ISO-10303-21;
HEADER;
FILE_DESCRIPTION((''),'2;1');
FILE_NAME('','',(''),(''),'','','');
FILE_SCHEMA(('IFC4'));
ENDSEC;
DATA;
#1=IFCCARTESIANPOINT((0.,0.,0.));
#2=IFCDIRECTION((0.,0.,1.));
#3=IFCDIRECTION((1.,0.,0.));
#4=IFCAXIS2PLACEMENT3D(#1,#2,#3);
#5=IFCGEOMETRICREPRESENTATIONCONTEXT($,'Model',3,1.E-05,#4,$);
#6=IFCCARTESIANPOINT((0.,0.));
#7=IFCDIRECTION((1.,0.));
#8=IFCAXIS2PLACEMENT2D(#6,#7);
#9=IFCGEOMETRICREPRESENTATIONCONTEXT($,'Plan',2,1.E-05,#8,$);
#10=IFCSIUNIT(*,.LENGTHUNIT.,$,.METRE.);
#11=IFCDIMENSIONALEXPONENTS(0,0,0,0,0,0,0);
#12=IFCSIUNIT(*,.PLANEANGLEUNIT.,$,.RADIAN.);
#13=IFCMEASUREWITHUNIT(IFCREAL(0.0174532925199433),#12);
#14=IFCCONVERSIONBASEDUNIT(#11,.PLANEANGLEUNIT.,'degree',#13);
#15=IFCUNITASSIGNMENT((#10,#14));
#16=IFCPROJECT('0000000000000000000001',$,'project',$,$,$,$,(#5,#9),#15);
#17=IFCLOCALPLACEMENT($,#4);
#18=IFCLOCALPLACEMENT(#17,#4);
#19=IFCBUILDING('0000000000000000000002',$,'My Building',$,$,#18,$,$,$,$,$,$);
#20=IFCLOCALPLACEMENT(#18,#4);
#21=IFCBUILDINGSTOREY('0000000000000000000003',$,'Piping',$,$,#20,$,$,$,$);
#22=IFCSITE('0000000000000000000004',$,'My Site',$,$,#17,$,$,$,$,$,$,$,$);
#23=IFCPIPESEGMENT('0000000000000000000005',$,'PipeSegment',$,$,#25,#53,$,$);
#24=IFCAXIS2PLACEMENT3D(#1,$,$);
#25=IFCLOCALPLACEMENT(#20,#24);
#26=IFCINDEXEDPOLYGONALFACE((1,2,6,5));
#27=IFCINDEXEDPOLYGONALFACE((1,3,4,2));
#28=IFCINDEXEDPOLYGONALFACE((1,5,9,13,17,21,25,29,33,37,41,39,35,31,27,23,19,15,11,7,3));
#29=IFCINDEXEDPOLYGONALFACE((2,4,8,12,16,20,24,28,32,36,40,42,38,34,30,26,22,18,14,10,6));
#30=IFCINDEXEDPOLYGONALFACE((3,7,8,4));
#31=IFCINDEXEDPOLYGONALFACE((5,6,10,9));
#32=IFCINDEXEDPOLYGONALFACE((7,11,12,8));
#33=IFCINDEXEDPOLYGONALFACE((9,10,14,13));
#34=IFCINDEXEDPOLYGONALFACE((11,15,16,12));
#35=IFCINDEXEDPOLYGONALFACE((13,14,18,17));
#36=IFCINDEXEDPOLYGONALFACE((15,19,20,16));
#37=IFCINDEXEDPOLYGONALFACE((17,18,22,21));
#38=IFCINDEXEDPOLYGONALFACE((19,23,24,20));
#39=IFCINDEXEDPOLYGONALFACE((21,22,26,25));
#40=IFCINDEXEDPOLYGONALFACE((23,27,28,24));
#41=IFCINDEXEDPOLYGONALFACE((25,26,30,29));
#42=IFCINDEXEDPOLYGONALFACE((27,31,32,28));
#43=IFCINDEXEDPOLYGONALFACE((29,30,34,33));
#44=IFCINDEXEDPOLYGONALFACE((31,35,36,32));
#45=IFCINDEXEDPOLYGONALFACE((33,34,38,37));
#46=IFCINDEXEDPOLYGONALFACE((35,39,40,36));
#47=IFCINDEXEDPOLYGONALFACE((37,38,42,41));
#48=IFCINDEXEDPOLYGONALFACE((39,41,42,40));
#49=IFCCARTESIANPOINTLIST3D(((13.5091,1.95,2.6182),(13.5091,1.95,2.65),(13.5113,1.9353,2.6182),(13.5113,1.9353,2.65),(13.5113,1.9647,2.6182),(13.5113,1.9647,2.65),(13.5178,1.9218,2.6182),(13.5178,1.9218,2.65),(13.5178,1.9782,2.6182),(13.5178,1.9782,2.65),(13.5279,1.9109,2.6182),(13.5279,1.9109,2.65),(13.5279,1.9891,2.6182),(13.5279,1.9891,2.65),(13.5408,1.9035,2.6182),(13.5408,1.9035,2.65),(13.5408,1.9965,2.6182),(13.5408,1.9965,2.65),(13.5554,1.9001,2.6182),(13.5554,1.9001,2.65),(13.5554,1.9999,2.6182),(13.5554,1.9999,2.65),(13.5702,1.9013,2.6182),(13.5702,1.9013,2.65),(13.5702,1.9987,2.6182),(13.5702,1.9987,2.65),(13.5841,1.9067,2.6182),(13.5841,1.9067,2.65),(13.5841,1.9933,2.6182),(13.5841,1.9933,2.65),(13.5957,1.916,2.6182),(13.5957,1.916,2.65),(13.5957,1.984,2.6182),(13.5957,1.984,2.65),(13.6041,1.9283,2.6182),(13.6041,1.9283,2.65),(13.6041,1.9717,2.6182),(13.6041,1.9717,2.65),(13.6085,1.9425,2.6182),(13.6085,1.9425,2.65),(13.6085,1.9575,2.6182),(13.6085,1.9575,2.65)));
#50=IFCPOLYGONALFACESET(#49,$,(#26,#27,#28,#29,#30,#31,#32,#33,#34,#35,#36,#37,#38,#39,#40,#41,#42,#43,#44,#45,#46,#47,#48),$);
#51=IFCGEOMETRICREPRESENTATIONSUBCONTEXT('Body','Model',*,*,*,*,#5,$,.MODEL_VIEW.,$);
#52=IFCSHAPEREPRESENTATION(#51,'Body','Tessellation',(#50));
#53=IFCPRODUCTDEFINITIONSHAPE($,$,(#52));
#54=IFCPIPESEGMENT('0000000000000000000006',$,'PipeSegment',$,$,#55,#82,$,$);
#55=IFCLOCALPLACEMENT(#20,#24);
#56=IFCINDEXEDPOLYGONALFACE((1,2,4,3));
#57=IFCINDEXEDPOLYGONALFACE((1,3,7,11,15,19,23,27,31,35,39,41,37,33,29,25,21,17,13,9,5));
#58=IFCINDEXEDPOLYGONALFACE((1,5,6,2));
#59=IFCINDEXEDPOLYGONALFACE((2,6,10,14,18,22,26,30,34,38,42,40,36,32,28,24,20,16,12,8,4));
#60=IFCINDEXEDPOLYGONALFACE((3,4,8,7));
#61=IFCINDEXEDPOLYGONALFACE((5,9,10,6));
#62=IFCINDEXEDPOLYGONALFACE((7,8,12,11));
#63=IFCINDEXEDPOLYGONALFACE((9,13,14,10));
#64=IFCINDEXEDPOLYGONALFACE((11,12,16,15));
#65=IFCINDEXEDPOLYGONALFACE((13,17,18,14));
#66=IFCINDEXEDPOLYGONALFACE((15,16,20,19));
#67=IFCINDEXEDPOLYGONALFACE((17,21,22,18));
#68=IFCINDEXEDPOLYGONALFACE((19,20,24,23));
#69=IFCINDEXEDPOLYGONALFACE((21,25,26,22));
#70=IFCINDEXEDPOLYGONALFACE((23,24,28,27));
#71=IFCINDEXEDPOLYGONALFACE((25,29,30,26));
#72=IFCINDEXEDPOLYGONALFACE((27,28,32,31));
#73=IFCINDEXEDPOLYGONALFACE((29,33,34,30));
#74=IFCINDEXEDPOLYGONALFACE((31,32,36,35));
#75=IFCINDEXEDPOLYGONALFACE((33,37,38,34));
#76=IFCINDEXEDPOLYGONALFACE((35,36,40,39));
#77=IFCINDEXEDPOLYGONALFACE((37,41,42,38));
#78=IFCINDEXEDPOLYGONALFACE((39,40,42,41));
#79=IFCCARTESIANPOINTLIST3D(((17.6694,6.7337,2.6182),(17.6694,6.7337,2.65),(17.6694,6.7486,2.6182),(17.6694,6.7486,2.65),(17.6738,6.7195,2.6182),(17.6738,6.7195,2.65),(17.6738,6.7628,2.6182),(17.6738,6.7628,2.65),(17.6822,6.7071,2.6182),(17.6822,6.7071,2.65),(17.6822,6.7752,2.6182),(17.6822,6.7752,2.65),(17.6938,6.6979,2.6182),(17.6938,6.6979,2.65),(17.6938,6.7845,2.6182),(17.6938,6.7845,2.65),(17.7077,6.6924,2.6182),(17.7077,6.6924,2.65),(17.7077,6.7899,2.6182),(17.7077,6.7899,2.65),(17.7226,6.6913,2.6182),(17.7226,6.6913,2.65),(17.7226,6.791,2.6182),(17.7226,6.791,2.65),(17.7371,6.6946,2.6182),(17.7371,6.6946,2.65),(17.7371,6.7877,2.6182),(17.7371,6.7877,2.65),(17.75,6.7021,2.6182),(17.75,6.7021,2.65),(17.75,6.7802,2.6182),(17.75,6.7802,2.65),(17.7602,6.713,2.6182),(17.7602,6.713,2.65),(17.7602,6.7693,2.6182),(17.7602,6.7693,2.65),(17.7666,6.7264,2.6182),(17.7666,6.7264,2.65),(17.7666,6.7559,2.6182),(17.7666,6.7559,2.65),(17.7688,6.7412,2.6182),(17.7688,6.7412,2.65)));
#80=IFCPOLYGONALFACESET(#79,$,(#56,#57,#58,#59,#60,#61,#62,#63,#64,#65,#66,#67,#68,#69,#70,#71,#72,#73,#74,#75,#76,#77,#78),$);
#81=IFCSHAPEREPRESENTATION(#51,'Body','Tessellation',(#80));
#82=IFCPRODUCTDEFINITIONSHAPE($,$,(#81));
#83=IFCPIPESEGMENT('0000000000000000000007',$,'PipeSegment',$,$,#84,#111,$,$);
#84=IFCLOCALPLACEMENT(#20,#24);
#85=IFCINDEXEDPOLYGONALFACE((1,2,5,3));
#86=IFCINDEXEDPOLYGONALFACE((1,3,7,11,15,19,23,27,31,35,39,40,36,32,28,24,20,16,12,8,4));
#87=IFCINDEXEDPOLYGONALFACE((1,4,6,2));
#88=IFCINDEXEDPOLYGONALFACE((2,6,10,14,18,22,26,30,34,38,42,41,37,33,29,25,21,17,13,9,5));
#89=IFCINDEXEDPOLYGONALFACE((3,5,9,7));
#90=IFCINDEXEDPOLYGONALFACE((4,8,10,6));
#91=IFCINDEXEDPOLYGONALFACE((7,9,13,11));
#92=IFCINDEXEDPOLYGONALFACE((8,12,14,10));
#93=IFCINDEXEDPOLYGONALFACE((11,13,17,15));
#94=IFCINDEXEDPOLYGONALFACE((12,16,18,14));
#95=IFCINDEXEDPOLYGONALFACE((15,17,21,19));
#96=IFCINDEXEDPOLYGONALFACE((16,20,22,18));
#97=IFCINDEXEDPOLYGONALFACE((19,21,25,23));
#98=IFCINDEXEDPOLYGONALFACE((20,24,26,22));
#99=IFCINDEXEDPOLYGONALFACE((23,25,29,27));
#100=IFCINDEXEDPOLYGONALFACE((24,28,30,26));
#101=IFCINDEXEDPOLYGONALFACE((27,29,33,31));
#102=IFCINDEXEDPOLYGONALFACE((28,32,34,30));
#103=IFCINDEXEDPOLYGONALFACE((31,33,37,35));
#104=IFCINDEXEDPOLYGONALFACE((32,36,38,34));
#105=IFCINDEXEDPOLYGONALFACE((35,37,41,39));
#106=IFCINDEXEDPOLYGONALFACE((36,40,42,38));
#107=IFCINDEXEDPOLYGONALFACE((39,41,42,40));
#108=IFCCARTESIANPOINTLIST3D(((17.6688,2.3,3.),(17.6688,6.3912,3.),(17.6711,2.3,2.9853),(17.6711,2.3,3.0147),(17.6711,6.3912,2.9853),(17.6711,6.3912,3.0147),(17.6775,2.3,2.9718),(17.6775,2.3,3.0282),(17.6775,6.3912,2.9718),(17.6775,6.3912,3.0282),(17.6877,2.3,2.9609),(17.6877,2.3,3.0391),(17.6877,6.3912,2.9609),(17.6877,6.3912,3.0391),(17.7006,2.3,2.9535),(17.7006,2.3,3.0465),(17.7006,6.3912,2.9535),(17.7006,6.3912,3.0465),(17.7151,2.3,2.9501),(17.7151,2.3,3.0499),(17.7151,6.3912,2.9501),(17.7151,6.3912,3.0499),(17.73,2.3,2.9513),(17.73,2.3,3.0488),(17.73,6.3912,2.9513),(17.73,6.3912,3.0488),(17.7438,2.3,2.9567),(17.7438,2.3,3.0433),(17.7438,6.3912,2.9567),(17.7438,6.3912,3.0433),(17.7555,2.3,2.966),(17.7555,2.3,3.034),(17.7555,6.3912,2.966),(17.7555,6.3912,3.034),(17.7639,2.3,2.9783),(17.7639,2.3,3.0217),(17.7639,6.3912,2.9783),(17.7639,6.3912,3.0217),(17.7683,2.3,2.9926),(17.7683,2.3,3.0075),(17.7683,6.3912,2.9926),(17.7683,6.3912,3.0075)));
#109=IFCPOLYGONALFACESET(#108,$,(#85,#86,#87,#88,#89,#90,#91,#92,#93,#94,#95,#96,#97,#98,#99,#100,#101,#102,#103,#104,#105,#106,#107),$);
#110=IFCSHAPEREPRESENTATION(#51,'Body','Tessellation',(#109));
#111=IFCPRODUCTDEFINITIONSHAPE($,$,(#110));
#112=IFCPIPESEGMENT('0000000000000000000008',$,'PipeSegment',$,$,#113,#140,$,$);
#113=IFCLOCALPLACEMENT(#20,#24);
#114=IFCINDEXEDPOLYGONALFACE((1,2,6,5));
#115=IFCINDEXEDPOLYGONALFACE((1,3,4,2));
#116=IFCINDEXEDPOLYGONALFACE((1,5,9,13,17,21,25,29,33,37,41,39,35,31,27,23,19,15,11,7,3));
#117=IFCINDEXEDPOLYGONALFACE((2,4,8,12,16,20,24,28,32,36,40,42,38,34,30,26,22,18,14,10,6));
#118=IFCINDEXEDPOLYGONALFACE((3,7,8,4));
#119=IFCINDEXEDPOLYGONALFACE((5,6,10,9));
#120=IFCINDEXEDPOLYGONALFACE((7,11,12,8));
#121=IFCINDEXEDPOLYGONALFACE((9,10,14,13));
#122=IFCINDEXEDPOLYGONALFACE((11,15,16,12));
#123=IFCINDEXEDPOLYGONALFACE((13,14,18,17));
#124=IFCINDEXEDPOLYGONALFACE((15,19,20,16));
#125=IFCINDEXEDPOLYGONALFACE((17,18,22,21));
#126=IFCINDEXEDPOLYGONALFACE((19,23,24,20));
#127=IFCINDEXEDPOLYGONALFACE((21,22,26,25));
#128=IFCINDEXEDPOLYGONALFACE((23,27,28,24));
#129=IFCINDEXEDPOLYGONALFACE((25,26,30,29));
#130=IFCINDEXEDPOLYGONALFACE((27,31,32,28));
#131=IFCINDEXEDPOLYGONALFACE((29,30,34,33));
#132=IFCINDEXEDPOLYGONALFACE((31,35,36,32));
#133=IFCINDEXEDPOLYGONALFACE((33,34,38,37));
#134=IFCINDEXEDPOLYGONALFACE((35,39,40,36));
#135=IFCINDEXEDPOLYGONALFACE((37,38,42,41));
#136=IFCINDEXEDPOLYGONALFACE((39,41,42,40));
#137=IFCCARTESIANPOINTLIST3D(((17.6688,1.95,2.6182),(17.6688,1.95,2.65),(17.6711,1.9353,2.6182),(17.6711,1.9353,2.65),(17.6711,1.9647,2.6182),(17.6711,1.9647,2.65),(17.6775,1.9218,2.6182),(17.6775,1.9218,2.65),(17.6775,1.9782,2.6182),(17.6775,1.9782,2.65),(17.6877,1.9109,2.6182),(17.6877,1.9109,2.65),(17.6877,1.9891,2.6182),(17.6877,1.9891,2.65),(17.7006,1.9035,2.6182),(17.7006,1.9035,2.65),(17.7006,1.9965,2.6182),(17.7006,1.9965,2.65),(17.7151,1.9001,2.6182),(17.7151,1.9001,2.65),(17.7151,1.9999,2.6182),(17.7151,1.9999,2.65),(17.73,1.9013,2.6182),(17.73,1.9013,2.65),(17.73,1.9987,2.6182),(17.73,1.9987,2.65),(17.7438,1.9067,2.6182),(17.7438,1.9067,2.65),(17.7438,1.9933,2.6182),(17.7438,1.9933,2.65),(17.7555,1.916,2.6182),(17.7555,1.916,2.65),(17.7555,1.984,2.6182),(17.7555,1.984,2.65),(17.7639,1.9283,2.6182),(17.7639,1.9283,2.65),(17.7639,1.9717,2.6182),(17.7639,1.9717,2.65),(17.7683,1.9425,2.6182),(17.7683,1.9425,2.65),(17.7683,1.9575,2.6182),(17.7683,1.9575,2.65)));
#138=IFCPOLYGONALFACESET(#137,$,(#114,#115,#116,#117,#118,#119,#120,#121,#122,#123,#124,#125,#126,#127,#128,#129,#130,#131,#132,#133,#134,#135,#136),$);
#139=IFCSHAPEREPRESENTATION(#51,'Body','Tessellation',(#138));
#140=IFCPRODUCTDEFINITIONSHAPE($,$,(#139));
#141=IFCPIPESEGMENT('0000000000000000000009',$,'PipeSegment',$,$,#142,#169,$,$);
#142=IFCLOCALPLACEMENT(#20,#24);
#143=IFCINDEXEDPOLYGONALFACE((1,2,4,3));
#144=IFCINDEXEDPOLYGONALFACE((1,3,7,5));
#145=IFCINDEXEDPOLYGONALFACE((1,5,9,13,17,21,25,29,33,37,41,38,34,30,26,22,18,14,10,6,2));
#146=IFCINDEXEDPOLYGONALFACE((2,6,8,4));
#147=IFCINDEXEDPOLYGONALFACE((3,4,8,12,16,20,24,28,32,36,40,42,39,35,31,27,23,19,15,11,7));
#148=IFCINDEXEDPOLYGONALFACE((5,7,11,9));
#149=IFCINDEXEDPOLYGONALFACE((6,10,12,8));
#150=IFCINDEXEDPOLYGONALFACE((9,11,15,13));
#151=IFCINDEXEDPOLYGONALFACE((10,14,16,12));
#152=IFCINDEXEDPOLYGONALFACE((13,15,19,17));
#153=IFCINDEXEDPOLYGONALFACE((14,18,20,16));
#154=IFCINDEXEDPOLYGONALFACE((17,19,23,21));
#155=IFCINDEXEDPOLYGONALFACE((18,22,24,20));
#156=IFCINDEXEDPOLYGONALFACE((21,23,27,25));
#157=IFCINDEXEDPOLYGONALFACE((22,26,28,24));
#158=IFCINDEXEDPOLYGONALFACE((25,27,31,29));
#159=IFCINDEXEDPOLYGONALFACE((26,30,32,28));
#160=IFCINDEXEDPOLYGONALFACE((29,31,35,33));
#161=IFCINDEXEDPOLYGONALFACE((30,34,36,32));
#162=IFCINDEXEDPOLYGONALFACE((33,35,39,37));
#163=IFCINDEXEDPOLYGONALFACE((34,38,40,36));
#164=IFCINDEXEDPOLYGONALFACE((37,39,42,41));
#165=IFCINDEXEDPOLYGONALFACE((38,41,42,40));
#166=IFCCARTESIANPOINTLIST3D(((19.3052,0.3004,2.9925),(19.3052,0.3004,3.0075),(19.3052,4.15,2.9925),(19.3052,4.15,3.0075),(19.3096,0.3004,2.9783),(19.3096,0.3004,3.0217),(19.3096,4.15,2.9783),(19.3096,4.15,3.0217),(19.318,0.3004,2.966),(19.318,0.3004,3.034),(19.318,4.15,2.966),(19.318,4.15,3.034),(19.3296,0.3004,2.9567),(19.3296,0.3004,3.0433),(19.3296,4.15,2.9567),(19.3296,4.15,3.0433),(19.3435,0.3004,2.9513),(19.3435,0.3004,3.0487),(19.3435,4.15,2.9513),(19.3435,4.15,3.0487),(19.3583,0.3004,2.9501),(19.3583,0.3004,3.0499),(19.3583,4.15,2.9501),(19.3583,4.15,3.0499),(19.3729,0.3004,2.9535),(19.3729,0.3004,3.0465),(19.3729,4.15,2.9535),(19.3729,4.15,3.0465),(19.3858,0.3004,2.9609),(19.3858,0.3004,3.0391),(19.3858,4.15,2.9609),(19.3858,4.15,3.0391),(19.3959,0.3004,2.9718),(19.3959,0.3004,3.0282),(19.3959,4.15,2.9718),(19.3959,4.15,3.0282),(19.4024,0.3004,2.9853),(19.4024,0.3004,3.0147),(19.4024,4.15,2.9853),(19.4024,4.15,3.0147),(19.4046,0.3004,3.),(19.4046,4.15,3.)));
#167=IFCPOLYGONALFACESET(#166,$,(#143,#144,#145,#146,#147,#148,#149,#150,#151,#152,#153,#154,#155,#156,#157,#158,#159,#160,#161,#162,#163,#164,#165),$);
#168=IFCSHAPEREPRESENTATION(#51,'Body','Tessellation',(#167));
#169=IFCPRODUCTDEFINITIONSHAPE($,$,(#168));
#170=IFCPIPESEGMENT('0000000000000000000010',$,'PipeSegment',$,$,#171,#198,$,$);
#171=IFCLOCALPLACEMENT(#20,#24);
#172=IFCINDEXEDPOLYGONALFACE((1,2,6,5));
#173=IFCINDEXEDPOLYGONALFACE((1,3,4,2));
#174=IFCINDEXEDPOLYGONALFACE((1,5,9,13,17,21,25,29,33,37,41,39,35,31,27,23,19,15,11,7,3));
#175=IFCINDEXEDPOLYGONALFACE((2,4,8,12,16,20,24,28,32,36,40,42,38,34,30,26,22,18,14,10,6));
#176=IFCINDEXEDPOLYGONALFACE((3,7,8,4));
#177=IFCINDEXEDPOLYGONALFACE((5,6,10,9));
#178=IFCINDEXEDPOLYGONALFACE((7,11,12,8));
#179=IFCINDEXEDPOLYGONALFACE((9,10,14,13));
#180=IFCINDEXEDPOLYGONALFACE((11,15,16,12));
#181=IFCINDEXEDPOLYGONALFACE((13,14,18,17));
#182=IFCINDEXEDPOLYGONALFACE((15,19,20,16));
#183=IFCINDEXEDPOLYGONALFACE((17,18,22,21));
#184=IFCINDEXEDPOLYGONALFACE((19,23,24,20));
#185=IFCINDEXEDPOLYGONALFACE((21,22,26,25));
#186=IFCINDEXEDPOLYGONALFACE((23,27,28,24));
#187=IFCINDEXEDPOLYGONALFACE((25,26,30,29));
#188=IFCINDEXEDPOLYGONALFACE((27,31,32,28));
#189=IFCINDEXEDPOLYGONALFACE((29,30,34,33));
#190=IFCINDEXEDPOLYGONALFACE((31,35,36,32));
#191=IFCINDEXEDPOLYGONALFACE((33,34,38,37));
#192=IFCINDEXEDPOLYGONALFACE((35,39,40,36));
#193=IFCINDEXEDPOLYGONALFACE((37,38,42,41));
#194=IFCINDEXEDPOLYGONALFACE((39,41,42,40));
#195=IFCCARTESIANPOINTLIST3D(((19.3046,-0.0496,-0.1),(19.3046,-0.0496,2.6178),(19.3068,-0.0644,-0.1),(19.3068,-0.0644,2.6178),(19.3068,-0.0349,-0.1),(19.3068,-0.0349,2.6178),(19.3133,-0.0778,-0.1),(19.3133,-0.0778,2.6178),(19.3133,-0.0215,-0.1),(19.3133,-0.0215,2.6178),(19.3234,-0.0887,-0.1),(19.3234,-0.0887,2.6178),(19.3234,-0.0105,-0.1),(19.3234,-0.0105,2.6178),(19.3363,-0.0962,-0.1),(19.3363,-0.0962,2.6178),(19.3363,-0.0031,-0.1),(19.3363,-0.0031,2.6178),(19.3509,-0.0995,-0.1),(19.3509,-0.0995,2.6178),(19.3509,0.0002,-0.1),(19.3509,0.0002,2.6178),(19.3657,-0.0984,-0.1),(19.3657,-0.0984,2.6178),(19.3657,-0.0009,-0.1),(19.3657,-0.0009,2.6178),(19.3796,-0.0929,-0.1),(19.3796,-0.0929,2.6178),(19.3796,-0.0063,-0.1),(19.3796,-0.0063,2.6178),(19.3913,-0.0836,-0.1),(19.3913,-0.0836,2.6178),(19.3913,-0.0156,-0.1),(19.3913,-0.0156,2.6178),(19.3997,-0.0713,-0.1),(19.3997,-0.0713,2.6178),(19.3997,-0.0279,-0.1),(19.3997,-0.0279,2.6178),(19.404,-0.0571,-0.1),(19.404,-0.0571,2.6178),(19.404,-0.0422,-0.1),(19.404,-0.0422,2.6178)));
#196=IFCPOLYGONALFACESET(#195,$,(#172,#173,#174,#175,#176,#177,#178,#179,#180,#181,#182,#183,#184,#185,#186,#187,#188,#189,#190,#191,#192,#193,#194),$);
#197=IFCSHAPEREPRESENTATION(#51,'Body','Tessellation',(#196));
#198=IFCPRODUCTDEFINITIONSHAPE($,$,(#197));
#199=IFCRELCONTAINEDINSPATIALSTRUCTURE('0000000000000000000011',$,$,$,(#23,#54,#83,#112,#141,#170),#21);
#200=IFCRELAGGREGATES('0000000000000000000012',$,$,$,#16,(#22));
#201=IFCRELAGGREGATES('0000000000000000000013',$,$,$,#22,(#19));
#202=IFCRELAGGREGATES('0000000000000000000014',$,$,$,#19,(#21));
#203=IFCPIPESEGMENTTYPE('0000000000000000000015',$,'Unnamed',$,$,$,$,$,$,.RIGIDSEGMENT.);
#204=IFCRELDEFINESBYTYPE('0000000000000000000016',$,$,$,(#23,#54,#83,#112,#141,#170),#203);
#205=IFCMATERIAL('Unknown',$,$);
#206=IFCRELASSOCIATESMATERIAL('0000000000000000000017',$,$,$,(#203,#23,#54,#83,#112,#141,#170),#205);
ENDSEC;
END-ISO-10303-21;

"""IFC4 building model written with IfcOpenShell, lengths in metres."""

from ifc_helpers import new_model, entity, si_unit, converted_unit, frame, origin_with_axes, origin_2d_with_axis, place, context, subcontext, project, spatial, circle, extrude, material, material_profile, profile_set, profile_usage, type_object, element, save


model = new_model("IFC4")

# Units and contexts
model_context = context("Model", 3, precision=1e-05, world=origin_with_axes())
plan_context = context("Plan", 2, precision=1e-05, world=origin_2d_with_axis())
body_context = subcontext(model_context, "Body", "Model", "MODEL_VIEW")
ifc_project = project(units=[si_unit("LENGTHUNIT", "METRE"), converted_unit("PLANEANGLEUNIT", "degree", entity("IfcReal", 0.0174532925199433), si_unit("PLANEANGLEUNIT", "RADIAN"), dimensions=[0, 0, 0, 0, 0, 0, 0])], contexts=[model_context, plan_context])

# Site, building, storey
site_placement = place(None, origin_with_axes())
site = spatial("IfcSite", under=ifc_project, at=site_placement, Name="My Site")
building_placement = place(site_placement, origin_with_axes())
building = spatial("IfcBuilding", under=site, at=building_placement, Name="My Building")
storey_placement = place(building_placement, origin_with_axes())
storey = spatial("IfcBuildingStorey", under=building, at=storey_placement, Name="Piping")

# Pipe segments
ifc_material = material(Name="Unknown")
ifc_material_profile = material_profile(ifc_material, circle(Radius=0.05))
ifc_profile_set = profile_set([ifc_material_profile])
pipe_segment_type = type_object("IfcPipeSegmentType", Name="Unnamed", PredefinedType="RIGIDSEGMENT", material=ifc_profile_set)
ifc_profile_usage_1 = profile_usage(ifc_profile_set, cardinal=5)
pipe_segment_1_placement = place(storey_placement, frame((13.5591, 1.95, 2.65), z_axis=(0.0, 0.0, -1.0), x_axis=(-1.0, 0.0, 0.0)))
element("IfcPipeSegment", 1, at=pipe_segment_1_placement, inside=storey, type_object=pipe_segment_type, material=ifc_profile_usage_1, Name="PipeSegment", context=body_context, shape_type="SweptSolid", body=[
    extrude(circle(Radius=0.05), origin_with_axes(), (0.0, 0.0, 1.0), 0.0318),
])
ifc_profile_usage_2 = profile_usage(ifc_profile_set, cardinal=5)
pipe_segment_2_placement = place(storey_placement, frame((17.7188, 6.7412, 2.65), z_axis=(0.0, 0.0, -1.0), x_axis=(1.0, 0.0, 0.0)))
element("IfcPipeSegment", 2, at=pipe_segment_2_placement, inside=storey, type_object=pipe_segment_type, material=ifc_profile_usage_2, Name="PipeSegment", context=body_context, shape_type="SweptSolid", body=[
    extrude(circle(Radius=0.05), origin_with_axes(), (0.0, 0.0, 1.0), 0.0318),
])
ifc_profile_usage_3 = profile_usage(ifc_profile_set, cardinal=5)
pipe_segment_3_placement = place(storey_placement, frame((17.7188, 2.3, 3.0), z_axis=(0.0, 1.0, 0.0), x_axis=(-1.0, 0.0, 0.0)))
element("IfcPipeSegment", 3, at=pipe_segment_3_placement, inside=storey, type_object=pipe_segment_type, material=ifc_profile_usage_3, Name="PipeSegment", context=body_context, shape_type="SweptSolid", body=[
    extrude(circle(Radius=0.05), origin_with_axes(), (0.0, 0.0, 1.0), 4.0912),
])
ifc_profile_usage_4 = profile_usage(ifc_profile_set, cardinal=5)
pipe_segment_4_placement = place(storey_placement, frame((17.7188, 1.95, 2.65), z_axis=(0.0, 0.0, -1.0), x_axis=(-1.0, 0.0, 0.0)))
element("IfcPipeSegment", 4, at=pipe_segment_4_placement, inside=storey, type_object=pipe_segment_type, material=ifc_profile_usage_4, Name="PipeSegment", context=body_context, shape_type="SweptSolid", body=[
    extrude(circle(Radius=0.05), origin_with_axes(), (0.0, 0.0, 1.0), 0.0318),
])
ifc_profile_usage_5 = profile_usage(ifc_profile_set, cardinal=5)
pipe_segment_5_placement = place(storey_placement, frame((19.3546, 4.15, 3.0), z_axis=(0.0, -1.0, 0.0), x_axis=(1.0, 0.0, 0.0)))
element("IfcPipeSegment", 5, at=pipe_segment_5_placement, inside=storey, type_object=pipe_segment_type, material=ifc_profile_usage_5, Name="PipeSegment", context=body_context, shape_type="SweptSolid", body=[
    extrude(circle(Radius=0.05), origin_with_axes(), (0.0, 0.0, 1.0), 3.8496),
])
ifc_profile_usage_6 = profile_usage(ifc_profile_set, cardinal=5)
pipe_segment_6_placement = place(storey_placement, frame((19.3546, -0.0496, 2.6178), z_axis=(0.0, 0.0, -1.0), x_axis=(-1.0, 0.0, 0.0)))
element("IfcPipeSegment", 6, at=pipe_segment_6_placement, inside=storey, type_object=pipe_segment_type, material=ifc_profile_usage_6, Name="PipeSegment", context=body_context, shape_type="SweptSolid", body=[
    extrude(circle(Radius=0.05), origin_with_axes(), (0.0, 0.0, 1.0), 2.7178),
])

save(model, "model.ifc")
